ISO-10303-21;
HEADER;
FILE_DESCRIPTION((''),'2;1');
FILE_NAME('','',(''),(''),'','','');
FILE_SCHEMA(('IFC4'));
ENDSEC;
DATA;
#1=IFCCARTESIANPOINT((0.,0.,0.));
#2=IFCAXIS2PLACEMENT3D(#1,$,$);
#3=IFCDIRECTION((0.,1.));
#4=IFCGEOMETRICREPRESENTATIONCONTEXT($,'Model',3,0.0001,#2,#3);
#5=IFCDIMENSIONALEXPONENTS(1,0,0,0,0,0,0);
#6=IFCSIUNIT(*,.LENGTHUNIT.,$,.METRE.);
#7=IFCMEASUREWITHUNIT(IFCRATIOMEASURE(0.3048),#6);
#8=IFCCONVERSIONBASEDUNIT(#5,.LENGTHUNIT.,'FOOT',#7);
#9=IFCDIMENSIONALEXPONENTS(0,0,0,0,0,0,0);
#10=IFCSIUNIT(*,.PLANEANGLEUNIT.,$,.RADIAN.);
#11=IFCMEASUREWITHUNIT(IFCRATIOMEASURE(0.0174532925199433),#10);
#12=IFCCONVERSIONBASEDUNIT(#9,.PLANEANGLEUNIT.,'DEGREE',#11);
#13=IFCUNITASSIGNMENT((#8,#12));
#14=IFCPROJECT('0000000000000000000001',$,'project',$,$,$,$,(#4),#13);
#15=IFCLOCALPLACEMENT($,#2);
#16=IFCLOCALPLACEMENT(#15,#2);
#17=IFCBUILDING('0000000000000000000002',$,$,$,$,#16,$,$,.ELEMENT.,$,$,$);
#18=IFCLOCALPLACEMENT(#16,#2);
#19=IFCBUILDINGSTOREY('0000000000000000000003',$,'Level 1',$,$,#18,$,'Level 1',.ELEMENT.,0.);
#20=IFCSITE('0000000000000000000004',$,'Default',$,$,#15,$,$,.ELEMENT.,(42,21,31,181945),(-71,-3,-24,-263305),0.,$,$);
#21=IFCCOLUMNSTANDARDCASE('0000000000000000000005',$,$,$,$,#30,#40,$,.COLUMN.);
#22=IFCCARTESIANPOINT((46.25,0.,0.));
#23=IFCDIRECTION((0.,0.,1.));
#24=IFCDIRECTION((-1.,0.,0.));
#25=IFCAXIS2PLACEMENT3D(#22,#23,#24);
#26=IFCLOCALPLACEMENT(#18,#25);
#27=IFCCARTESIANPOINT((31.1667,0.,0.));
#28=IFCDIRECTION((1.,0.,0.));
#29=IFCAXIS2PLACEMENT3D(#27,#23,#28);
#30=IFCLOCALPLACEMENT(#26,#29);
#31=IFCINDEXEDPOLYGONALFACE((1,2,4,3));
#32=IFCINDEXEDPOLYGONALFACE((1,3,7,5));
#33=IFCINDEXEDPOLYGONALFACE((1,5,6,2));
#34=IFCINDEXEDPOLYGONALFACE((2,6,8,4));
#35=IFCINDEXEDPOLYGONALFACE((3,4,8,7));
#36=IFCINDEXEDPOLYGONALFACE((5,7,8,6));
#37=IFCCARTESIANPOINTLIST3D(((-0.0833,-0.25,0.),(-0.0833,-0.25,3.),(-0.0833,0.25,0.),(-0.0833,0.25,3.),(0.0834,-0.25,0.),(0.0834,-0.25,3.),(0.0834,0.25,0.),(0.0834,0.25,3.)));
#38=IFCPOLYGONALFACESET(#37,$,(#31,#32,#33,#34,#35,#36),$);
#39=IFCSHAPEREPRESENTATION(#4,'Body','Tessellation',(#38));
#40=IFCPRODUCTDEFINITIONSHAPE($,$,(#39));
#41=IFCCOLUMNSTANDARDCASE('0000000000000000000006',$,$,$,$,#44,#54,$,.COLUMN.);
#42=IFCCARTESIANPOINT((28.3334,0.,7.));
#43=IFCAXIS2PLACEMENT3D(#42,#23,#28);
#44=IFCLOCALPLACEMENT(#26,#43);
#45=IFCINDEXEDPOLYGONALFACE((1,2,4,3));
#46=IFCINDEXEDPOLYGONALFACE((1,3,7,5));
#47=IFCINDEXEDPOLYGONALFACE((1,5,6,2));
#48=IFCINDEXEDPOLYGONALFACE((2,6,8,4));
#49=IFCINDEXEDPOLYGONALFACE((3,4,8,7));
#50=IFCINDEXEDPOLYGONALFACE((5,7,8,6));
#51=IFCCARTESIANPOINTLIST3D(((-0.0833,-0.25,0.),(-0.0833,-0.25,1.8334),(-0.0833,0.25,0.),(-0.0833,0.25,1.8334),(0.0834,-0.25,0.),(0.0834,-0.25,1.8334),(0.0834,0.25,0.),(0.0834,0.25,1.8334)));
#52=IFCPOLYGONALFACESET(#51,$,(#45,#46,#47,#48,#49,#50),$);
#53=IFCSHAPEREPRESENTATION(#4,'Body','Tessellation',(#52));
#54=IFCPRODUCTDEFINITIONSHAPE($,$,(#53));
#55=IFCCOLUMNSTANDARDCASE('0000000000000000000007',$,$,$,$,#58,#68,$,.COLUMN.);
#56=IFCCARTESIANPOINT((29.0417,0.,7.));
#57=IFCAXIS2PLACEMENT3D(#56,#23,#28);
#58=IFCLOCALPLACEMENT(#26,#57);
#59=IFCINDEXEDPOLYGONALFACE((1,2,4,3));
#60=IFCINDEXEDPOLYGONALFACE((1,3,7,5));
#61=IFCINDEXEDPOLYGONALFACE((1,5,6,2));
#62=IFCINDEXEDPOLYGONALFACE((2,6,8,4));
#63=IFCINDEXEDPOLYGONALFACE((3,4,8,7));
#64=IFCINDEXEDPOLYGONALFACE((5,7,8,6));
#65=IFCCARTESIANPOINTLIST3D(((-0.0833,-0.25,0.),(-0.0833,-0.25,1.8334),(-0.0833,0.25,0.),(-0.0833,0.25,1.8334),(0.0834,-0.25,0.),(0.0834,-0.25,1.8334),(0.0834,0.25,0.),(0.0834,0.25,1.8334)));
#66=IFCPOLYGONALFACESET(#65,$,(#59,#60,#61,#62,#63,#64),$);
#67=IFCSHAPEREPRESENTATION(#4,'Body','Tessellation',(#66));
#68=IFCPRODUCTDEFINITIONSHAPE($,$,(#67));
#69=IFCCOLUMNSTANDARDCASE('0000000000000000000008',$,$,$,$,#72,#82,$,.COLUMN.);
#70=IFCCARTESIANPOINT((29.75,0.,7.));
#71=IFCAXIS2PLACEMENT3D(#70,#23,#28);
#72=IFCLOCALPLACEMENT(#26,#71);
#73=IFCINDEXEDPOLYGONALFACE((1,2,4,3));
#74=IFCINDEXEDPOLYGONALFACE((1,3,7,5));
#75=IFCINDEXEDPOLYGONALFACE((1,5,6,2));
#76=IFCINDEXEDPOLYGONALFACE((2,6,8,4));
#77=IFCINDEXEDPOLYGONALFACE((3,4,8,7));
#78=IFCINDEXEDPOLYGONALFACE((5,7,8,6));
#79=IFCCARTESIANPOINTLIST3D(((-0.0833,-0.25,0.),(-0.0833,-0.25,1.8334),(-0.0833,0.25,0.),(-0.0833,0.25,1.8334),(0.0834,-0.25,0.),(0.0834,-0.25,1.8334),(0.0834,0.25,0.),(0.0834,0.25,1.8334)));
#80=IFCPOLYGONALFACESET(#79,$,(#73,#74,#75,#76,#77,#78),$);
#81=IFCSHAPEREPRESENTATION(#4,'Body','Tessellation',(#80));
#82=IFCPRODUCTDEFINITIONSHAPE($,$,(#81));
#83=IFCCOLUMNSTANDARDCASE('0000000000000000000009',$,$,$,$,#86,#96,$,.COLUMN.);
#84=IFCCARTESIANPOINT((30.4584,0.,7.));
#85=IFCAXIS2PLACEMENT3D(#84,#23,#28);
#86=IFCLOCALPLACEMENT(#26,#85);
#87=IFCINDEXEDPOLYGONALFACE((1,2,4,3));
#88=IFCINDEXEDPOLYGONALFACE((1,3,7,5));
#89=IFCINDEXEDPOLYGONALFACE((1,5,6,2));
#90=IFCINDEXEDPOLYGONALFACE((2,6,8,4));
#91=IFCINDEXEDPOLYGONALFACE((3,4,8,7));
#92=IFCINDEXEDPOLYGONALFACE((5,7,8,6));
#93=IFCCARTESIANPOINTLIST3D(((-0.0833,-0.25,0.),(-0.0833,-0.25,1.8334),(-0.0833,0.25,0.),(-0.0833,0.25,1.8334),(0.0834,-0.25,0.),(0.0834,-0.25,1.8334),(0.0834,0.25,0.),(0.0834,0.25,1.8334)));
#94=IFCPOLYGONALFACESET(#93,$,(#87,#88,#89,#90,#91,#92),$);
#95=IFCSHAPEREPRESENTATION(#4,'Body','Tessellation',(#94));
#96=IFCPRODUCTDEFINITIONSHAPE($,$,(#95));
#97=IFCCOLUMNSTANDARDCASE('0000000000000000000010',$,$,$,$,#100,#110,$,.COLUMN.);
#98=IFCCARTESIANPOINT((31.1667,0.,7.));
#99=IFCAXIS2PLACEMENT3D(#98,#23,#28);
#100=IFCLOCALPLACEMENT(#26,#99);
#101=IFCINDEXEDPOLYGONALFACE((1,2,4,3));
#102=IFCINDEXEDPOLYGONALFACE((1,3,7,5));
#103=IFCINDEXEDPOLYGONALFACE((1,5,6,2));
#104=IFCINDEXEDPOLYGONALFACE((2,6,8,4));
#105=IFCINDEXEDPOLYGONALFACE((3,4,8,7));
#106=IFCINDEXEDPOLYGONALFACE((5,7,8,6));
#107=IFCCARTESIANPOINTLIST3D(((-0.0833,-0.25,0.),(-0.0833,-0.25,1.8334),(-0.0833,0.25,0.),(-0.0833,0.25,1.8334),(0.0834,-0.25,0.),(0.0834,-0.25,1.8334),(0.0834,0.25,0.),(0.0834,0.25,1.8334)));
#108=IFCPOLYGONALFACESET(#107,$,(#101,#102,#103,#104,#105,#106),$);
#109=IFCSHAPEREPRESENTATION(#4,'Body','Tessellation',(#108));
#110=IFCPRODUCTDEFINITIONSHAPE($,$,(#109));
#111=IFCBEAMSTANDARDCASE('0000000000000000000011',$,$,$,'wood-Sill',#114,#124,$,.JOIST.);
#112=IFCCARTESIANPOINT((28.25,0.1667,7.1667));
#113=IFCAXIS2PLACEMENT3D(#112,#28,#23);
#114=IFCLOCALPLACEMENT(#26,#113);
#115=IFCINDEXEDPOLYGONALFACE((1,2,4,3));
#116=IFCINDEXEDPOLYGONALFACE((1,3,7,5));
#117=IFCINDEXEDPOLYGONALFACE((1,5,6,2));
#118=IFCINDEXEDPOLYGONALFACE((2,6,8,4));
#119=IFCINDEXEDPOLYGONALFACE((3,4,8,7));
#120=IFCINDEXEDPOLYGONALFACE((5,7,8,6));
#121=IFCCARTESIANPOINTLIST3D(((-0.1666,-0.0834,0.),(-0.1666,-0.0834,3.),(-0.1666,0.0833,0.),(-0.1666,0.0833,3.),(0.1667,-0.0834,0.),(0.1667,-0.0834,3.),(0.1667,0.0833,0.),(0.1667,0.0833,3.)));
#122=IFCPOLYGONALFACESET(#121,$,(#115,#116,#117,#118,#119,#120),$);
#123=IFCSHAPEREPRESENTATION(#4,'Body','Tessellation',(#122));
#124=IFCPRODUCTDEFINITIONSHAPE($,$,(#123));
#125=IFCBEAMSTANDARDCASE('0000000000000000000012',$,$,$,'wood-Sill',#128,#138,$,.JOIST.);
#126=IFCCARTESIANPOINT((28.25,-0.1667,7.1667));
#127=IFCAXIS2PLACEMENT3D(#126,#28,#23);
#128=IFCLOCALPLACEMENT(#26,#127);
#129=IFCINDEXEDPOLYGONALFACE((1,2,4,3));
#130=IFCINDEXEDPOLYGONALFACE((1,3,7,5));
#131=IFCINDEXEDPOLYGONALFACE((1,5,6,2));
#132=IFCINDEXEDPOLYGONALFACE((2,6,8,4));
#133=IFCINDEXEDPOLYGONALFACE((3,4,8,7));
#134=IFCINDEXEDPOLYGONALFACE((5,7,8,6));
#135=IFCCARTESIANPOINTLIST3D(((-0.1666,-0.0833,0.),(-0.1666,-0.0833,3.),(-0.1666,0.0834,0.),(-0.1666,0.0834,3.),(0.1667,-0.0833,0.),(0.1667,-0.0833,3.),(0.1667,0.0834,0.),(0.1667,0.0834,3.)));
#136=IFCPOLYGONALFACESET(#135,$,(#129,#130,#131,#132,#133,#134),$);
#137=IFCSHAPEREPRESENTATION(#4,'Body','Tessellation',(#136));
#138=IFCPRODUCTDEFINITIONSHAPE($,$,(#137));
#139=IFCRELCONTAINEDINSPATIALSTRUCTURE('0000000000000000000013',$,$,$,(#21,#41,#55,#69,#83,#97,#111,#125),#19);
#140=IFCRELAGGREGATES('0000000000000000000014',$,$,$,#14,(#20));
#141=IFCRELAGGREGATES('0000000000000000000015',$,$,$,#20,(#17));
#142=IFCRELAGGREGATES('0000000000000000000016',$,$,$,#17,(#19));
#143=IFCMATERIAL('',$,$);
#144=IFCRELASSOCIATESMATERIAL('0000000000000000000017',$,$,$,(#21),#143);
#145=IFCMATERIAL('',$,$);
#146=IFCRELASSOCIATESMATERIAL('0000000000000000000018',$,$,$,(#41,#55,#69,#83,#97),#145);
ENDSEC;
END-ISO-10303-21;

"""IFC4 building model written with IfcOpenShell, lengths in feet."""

from ifc_helpers import new_model, entity, si_unit, converted_unit, direction, frame, origin, origin_with_axes, place, context, project, spatial, rectangle, extrude, material, element, save


model = new_model("IFC4")

# Units and contexts
model_context = context("Model", 3, precision=0.0001, world=origin(), true_north=direction((0.0, 1.0)))
ifc_project = project(units=[converted_unit("LENGTHUNIT", "FOOT", entity("IfcRatioMeasure", 0.3048), si_unit("LENGTHUNIT", "METRE"), dimensions=[1, 0, 0, 0, 0, 0, 0]), converted_unit("PLANEANGLEUNIT", "DEGREE", entity("IfcRatioMeasure", 0.0174532925199433), si_unit("PLANEANGLEUNIT", "RADIAN"), dimensions=[0, 0, 0, 0, 0, 0, 0])], contexts=[model_context])

# Site, building, storey
site_placement = place(None, origin())
site = spatial("IfcSite", under=ifc_project, at=site_placement, Name="Default", CompositionType="ELEMENT", RefLatitude=(42, 21, 31, 181945), RefLongitude=(-71, -3, -24, -263305), RefElevation=0.0)
building_placement = place(site_placement, origin())
building = spatial("IfcBuilding", under=site, at=building_placement, CompositionType="ELEMENT")
storey_placement = place(building_placement, origin())
storey = spatial("IfcBuildingStorey", under=building, at=storey_placement, Name="Level 1", LongName="Level 1", CompositionType="ELEMENT", Elevation=0.0)

# Columns
placement_1 = place(storey_placement, frame((46.25, 0.0, 0.0), z_axis=(0.0, 0.0, 1.0), x_axis=(-1.0, 0.0, 0.0)))
ifc_material_1 = material(Name="")
for number, where, z_axis, x_axis in (
    (1, (31.1667, 0.0, 0.0), (0.0, 0.0, 1.0), (1.0, 0.0, 0.0)),
):
    element("IfcColumnStandardCase", number, at=place(placement_1, frame(where, z_axis=z_axis, x_axis=x_axis)), inside=storey, material=ifc_material_1, PredefinedType="COLUMN", context=model_context, shape_type="SweptSolid", body=[
        extrude(rectangle(XDim=0.1667, YDim=0.5), origin(), (0.0, 0.0, 1.0), 3.0),
    ])
ifc_material_2 = material(Name="")
for number, where, z_axis, x_axis in (
    (2, (28.3334, 0.0, 7.0), (0.0, 0.0, 1.0), (1.0, 0.0, 0.0)),
    (3, (29.0417, 0.0, 7.0), (0.0, 0.0, 1.0), (1.0, 0.0, 0.0)),
    (4, (29.75, 0.0, 7.0), (0.0, 0.0, 1.0), (1.0, 0.0, 0.0)),
    (5, (30.4584, 0.0, 7.0), (0.0, 0.0, 1.0), (1.0, 0.0, 0.0)),
    (6, (31.1667, 0.0, 7.0), (0.0, 0.0, 1.0), (1.0, 0.0, 0.0)),
):
    element("IfcColumnStandardCase", number, at=place(placement_1, frame(where, z_axis=z_axis, x_axis=x_axis)), inside=storey, material=ifc_material_2, PredefinedType="COLUMN", context=model_context, shape_type="SweptSolid", body=[
        extrude(rectangle(XDim=0.1667, YDim=0.5), origin(), (0.0, 0.0, 1.0), 1.8334),
    ])

# Beams
for number, where, z_axis, x_axis in (
    (7, (28.25, 0.1667, 7.1667), (1.0, 0.0, 0.0), (0.0, 0.0, 1.0)),
    (8, (28.25, -0.1667, 7.1667), (1.0, 0.0, 0.0), (0.0, 0.0, 1.0)),
):
    element("IfcBeamStandardCase", number, at=place(placement_1, frame(where, z_axis=z_axis, x_axis=x_axis)), inside=storey, ObjectType="wood-Sill", PredefinedType="JOIST", context=model_context, shape_type="SweptSolid", body=[
        extrude(rectangle(XDim=0.3333, YDim=0.1667), origin_with_axes(), (0.0, 0.0, 1.0), 3.0),
    ])

save(model, "model.ifc")
